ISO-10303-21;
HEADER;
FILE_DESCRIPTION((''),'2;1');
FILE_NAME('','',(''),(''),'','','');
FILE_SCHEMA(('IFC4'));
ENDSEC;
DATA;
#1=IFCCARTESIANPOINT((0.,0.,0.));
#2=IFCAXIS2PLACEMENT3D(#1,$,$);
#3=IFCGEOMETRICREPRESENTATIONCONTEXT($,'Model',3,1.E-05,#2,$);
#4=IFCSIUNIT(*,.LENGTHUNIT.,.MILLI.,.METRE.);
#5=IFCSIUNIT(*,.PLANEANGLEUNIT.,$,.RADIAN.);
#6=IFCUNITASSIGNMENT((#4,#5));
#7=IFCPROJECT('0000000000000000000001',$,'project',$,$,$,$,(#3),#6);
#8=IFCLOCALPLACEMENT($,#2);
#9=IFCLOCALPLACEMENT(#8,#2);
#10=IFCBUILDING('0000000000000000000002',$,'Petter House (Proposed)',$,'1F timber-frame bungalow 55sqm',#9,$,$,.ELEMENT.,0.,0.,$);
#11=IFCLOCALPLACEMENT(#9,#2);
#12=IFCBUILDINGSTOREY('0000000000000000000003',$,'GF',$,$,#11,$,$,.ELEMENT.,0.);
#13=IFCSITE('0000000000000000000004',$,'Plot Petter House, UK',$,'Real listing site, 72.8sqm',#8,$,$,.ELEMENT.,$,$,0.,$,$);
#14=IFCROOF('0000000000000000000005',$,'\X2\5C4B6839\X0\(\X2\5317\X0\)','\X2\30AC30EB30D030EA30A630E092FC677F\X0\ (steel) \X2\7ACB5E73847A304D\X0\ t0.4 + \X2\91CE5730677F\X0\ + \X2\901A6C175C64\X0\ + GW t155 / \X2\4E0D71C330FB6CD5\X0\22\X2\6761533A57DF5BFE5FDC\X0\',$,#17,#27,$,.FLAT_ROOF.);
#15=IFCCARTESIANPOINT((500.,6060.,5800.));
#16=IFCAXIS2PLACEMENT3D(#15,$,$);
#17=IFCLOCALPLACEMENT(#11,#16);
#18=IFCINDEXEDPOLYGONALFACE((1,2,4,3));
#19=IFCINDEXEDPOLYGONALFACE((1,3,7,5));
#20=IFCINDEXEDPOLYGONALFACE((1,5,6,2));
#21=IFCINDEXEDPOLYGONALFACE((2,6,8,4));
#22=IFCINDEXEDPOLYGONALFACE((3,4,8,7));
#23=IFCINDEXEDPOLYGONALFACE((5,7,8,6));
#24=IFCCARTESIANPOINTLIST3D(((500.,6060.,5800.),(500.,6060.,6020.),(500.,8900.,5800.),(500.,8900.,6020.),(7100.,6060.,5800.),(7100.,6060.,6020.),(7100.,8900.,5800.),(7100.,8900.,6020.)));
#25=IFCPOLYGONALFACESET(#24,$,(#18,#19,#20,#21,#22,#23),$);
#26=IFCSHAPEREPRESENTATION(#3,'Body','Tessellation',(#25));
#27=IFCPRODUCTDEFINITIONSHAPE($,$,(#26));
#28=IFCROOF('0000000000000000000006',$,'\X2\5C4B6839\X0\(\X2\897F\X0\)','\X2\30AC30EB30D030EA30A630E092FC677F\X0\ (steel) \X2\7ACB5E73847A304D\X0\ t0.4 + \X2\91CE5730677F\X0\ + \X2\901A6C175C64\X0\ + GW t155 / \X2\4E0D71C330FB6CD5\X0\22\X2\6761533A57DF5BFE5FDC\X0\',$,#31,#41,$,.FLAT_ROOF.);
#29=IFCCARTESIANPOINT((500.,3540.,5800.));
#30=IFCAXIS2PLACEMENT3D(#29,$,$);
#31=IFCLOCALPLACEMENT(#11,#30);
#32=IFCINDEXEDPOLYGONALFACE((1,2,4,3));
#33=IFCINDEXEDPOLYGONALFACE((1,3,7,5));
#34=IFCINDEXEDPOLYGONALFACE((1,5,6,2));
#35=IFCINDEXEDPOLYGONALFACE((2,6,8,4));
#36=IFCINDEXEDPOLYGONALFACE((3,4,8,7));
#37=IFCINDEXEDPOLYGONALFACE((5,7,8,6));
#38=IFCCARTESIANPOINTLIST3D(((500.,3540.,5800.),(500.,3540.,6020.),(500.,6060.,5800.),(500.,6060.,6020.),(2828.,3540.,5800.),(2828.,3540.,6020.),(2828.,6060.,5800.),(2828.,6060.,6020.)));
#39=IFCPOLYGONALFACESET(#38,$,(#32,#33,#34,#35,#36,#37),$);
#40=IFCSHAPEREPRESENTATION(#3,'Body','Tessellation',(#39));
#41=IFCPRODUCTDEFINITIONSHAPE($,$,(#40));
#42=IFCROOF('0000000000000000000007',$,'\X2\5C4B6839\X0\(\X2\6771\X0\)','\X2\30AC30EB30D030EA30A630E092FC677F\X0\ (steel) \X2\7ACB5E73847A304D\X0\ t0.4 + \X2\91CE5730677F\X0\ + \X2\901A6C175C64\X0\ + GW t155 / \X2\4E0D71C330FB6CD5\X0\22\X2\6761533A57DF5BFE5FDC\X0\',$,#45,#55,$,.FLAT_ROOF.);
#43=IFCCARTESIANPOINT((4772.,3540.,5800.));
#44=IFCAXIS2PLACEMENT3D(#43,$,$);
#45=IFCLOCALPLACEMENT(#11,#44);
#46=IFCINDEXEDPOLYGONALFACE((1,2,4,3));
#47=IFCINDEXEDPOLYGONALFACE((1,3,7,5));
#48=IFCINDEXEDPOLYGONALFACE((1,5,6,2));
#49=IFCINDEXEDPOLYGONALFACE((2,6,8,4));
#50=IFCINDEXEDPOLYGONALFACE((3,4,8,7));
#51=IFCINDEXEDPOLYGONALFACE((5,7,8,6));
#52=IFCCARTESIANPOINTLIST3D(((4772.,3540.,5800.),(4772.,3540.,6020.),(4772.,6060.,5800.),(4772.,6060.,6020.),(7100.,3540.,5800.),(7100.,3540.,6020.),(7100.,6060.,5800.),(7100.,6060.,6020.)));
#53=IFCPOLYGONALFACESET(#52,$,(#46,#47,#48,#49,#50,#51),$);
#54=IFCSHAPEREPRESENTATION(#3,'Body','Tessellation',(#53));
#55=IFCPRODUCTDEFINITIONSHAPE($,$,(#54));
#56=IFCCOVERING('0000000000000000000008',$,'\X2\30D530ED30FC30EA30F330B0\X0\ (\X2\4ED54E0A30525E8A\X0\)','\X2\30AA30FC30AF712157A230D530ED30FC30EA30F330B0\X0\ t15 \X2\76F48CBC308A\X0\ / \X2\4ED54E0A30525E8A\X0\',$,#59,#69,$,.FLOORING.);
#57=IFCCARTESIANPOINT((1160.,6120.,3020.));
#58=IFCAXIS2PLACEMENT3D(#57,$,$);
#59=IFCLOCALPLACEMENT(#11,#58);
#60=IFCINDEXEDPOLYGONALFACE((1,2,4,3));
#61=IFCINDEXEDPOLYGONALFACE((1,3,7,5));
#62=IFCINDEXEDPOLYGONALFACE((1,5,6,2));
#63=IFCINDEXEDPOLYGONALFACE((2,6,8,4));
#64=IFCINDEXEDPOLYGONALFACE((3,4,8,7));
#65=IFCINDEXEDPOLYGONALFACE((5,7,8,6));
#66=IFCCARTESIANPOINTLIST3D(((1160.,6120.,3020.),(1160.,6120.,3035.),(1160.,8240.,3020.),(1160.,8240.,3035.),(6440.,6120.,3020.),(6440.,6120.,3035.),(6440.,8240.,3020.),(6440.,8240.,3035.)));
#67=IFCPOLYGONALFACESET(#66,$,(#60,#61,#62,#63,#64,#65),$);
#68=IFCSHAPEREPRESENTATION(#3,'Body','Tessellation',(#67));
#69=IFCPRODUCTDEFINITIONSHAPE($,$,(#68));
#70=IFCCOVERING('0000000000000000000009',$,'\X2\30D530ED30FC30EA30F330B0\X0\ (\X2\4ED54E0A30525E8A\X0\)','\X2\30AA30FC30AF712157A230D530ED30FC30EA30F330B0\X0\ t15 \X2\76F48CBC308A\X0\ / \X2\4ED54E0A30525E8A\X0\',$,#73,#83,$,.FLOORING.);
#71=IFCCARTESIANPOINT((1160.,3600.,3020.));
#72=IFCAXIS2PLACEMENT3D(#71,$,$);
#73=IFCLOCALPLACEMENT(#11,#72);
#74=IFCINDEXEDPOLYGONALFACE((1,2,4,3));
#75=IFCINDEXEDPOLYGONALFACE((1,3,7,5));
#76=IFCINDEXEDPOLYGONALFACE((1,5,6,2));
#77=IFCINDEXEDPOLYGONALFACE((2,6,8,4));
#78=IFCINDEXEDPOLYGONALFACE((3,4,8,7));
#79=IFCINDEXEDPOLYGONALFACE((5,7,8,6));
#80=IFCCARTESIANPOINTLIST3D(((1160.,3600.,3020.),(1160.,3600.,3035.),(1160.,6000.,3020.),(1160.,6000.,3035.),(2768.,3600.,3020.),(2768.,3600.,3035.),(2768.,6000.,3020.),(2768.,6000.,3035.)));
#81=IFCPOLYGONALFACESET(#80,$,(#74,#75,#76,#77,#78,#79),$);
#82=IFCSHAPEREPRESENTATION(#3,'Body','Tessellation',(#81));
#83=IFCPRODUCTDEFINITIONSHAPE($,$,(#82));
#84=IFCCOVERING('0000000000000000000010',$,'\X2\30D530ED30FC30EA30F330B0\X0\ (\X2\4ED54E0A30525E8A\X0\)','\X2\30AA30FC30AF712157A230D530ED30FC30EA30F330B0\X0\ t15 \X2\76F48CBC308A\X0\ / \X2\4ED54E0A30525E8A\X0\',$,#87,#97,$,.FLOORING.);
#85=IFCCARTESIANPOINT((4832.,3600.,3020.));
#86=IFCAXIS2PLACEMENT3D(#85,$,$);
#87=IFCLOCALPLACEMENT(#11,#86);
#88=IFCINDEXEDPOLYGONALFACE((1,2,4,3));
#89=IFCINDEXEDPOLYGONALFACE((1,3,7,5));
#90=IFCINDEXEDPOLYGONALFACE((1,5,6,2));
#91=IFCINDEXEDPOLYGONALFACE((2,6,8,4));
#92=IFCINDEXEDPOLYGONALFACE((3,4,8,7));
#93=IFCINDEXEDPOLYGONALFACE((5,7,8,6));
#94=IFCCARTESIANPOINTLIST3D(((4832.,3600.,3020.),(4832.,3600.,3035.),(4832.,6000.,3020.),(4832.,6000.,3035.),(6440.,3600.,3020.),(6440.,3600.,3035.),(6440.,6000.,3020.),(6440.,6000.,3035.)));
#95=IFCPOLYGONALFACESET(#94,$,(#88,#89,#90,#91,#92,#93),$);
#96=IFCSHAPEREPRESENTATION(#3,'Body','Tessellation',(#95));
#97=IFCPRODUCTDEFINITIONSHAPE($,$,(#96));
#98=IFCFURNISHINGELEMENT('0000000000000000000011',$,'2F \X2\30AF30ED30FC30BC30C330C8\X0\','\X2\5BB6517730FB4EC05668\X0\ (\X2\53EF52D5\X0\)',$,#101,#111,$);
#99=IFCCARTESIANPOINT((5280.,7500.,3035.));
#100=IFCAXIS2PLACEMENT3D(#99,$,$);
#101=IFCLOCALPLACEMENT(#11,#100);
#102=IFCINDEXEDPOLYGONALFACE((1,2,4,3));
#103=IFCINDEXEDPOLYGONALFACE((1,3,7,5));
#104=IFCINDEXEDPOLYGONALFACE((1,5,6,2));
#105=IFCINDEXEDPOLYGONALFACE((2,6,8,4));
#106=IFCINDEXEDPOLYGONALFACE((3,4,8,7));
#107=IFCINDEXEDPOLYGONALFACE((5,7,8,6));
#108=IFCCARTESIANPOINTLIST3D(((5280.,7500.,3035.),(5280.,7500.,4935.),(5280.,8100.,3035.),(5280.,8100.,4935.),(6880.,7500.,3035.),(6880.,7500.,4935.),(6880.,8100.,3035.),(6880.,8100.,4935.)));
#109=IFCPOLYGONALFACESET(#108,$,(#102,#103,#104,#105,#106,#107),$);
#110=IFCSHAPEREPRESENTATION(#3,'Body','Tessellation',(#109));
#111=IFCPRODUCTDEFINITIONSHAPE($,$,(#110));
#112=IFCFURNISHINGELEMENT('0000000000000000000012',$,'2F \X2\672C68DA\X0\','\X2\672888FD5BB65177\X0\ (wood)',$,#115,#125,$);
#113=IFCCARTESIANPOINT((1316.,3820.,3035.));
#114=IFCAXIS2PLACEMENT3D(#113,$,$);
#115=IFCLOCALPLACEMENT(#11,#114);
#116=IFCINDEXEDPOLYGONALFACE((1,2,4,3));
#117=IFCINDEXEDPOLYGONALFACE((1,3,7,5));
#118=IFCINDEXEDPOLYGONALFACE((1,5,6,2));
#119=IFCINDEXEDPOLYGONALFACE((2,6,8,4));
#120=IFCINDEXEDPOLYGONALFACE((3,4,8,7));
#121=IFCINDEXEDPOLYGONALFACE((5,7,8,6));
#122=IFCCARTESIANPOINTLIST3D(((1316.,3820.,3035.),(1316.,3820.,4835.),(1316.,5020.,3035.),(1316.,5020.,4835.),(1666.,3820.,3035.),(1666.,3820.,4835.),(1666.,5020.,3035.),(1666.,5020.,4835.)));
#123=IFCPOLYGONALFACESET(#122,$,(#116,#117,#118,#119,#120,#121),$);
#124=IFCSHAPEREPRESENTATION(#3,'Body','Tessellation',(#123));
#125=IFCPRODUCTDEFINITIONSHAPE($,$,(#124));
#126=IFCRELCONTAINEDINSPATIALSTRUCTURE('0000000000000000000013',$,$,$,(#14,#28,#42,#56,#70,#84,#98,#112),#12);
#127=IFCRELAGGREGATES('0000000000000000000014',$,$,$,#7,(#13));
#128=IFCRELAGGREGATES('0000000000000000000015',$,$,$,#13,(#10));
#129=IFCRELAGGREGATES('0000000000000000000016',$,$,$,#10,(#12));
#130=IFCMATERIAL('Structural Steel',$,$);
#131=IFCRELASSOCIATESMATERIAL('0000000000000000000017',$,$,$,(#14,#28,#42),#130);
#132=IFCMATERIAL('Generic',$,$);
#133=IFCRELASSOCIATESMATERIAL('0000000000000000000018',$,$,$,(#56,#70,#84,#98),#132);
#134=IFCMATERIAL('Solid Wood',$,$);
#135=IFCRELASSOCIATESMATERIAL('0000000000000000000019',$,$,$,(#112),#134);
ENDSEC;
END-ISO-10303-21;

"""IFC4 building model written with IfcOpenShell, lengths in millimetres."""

from ifc_helpers import new_model, si_unit, frame, frame_2d, origin, place, context, project, spatial, rectangle, extrude, material, element, save


model = new_model("IFC4")

# Units and contexts
model_context = context("Model", 3, precision=1e-05, world=origin())
ifc_project = project(units=[si_unit("LENGTHUNIT", "METRE", prefix="MILLI"), si_unit("PLANEANGLEUNIT", "RADIAN")], contexts=[model_context])

# Site, building, storey
site_placement = place(None, origin())
site = spatial("IfcSite", under=ifc_project, at=site_placement, Name="Plot Petter House, UK", ObjectType="Real listing site, 72.8sqm", CompositionType="ELEMENT", RefElevation=0.0)
building_placement = place(site_placement, origin())
building = spatial("IfcBuilding", under=site, at=building_placement, Name="Petter House (Proposed)", ObjectType="1F timber-frame bungalow 55sqm", CompositionType="ELEMENT", ElevationOfRefHeight=0.0, ElevationOfTerrain=0.0)
storey_placement = place(building_placement, origin())
storey = spatial("IfcBuildingStorey", under=building, at=storey_placement, Name="GF", CompositionType="ELEMENT", Elevation=0.0)

# Shared definitions
ifc_material_1 = material(Name="Solid Wood")

# Shared definitions
ifc_material_2 = material(Name="Generic")

# Roofs
ifc_material_3 = material(Name="Structural Steel")
for number, where, name in (
    (1, (500.0, 6060.0, 5800.0), "屋根(北)"),
):
    element("IfcRoof", number, at=place(storey_placement, frame(where)), inside=storey, material=ifc_material_3, Name=name, Description="ガルバリウム鋼板 (steel) 立平葺き t0.4 + 野地板 + 通気層 + GW t155 / 不燃・法22条区域対応", PredefinedType="FLAT_ROOF", context=model_context, shape_type="SweptSolid", body=[
        extrude(rectangle(XDim=6600.0, YDim=2840.0, at=frame_2d((3300.0, 1420.0))), frame((500.0, 6060.0, 5800.0)), (0.0, 0.0, 1.0), 220.0),
    ])
roof_1_placement = place(storey_placement, frame((500.0, 3540.0, 5800.0)))
element("IfcRoof", 2, at=roof_1_placement, inside=storey, material=ifc_material_3, Name="屋根(西)", Description="ガルバリウム鋼板 (steel) 立平葺き t0.4 + 野地板 + 通気層 + GW t155 / 不燃・法22条区域対応", PredefinedType="FLAT_ROOF", context=model_context, shape_type="SweptSolid", body=[
    extrude(rectangle(XDim=2328.0, YDim=2520.0, at=frame_2d((1164.0, 1260.0))), frame((500.0, 3540.0, 5800.0)), (0.0, 0.0, 1.0), 220.0),
])
roof_2_placement = place(storey_placement, frame((4772.0, 3540.0, 5800.0)))
element("IfcRoof", 3, at=roof_2_placement, inside=storey, material=ifc_material_3, Name="屋根(東)", Description="ガルバリウム鋼板 (steel) 立平葺き t0.4 + 野地板 + 通気層 + GW t155 / 不燃・法22条区域対応", PredefinedType="FLAT_ROOF", context=model_context, shape_type="SweptSolid", body=[
    extrude(rectangle(XDim=2328.0, YDim=2520.0, at=frame_2d((1164.0, 1260.0))), frame((4772.0, 3540.0, 5800.0)), (0.0, 0.0, 1.0), 220.0),
])

# Coverings
covering_1_placement = place(storey_placement, frame((1160.0, 6120.0, 3020.0)))
element("IfcCovering", 4, at=covering_1_placement, inside=storey, material=ifc_material_2, Name="フローリング (仕上げ床)", Description="オーク無垢フローリング t15 直貼り / 仕上げ床", PredefinedType="FLOORING", context=model_context, shape_type="SweptSolid", body=[
    extrude(rectangle(XDim=5280.0, YDim=2120.0, at=frame_2d((2640.0, 1060.0))), frame((1160.0, 6120.0, 3020.0)), (0.0, 0.0, 1.0), 15.0),
])
covering_2_placement = place(storey_placement, frame((1160.0, 3600.0, 3020.0)))
element("IfcCovering", 5, at=covering_2_placement, inside=storey, material=ifc_material_2, Name="フローリング (仕上げ床)", Description="オーク無垢フローリング t15 直貼り / 仕上げ床", PredefinedType="FLOORING", context=model_context, shape_type="SweptSolid", body=[
    extrude(rectangle(XDim=1608.0, YDim=2400.0, at=frame_2d((804.0, 1200.0))), frame((1160.0, 3600.0, 3020.0)), (0.0, 0.0, 1.0), 15.0),
])
covering_3_placement = place(storey_placement, frame((4832.0, 3600.0, 3020.0)))
element("IfcCovering", 6, at=covering_3_placement, inside=storey, material=ifc_material_2, Name="フローリング (仕上げ床)", Description="オーク無垢フローリング t15 直貼り / 仕上げ床", PredefinedType="FLOORING", context=model_context, shape_type="SweptSolid", body=[
    extrude(rectangle(XDim=1608.0, YDim=2400.0, at=frame_2d((804.0, 1200.0))), frame((4832.0, 3600.0, 3020.0)), (0.0, 0.0, 1.0), 15.0),
])

# Furnishing elements
furnishing_1_placement = place(storey_placement, frame((5280.0, 7500.0, 3035.0)))
element("IfcFurnishingElement", 7, at=furnishing_1_placement, inside=storey, material=ifc_material_2, Name="2F クローゼット", Description="家具・什器 (可動)", context=model_context, shape_type="SweptSolid", body=[
    extrude(rectangle(XDim=1600.0, YDim=600.0, at=frame_2d((800.0, 300.0))), frame((5280.0, 7500.0, 3035.0)), (0.0, 0.0, 1.0), 1900.0),
])
furnishing_2_placement = place(storey_placement, frame((1316.0, 3820.0, 3035.0)))
element("IfcFurnishingElement", 8, at=furnishing_2_placement, inside=storey, material=ifc_material_1, Name="2F 本棚", Description="木製家具 (wood)", context=model_context, shape_type="SweptSolid", body=[
    extrude(rectangle(XDim=350.0, YDim=1200.0, at=frame_2d((175.0, 600.0))), frame((1316.0, 3820.0, 3035.0)), (0.0, 0.0, 1.0), 1800.0),
])

save(model, "model.ifc")
